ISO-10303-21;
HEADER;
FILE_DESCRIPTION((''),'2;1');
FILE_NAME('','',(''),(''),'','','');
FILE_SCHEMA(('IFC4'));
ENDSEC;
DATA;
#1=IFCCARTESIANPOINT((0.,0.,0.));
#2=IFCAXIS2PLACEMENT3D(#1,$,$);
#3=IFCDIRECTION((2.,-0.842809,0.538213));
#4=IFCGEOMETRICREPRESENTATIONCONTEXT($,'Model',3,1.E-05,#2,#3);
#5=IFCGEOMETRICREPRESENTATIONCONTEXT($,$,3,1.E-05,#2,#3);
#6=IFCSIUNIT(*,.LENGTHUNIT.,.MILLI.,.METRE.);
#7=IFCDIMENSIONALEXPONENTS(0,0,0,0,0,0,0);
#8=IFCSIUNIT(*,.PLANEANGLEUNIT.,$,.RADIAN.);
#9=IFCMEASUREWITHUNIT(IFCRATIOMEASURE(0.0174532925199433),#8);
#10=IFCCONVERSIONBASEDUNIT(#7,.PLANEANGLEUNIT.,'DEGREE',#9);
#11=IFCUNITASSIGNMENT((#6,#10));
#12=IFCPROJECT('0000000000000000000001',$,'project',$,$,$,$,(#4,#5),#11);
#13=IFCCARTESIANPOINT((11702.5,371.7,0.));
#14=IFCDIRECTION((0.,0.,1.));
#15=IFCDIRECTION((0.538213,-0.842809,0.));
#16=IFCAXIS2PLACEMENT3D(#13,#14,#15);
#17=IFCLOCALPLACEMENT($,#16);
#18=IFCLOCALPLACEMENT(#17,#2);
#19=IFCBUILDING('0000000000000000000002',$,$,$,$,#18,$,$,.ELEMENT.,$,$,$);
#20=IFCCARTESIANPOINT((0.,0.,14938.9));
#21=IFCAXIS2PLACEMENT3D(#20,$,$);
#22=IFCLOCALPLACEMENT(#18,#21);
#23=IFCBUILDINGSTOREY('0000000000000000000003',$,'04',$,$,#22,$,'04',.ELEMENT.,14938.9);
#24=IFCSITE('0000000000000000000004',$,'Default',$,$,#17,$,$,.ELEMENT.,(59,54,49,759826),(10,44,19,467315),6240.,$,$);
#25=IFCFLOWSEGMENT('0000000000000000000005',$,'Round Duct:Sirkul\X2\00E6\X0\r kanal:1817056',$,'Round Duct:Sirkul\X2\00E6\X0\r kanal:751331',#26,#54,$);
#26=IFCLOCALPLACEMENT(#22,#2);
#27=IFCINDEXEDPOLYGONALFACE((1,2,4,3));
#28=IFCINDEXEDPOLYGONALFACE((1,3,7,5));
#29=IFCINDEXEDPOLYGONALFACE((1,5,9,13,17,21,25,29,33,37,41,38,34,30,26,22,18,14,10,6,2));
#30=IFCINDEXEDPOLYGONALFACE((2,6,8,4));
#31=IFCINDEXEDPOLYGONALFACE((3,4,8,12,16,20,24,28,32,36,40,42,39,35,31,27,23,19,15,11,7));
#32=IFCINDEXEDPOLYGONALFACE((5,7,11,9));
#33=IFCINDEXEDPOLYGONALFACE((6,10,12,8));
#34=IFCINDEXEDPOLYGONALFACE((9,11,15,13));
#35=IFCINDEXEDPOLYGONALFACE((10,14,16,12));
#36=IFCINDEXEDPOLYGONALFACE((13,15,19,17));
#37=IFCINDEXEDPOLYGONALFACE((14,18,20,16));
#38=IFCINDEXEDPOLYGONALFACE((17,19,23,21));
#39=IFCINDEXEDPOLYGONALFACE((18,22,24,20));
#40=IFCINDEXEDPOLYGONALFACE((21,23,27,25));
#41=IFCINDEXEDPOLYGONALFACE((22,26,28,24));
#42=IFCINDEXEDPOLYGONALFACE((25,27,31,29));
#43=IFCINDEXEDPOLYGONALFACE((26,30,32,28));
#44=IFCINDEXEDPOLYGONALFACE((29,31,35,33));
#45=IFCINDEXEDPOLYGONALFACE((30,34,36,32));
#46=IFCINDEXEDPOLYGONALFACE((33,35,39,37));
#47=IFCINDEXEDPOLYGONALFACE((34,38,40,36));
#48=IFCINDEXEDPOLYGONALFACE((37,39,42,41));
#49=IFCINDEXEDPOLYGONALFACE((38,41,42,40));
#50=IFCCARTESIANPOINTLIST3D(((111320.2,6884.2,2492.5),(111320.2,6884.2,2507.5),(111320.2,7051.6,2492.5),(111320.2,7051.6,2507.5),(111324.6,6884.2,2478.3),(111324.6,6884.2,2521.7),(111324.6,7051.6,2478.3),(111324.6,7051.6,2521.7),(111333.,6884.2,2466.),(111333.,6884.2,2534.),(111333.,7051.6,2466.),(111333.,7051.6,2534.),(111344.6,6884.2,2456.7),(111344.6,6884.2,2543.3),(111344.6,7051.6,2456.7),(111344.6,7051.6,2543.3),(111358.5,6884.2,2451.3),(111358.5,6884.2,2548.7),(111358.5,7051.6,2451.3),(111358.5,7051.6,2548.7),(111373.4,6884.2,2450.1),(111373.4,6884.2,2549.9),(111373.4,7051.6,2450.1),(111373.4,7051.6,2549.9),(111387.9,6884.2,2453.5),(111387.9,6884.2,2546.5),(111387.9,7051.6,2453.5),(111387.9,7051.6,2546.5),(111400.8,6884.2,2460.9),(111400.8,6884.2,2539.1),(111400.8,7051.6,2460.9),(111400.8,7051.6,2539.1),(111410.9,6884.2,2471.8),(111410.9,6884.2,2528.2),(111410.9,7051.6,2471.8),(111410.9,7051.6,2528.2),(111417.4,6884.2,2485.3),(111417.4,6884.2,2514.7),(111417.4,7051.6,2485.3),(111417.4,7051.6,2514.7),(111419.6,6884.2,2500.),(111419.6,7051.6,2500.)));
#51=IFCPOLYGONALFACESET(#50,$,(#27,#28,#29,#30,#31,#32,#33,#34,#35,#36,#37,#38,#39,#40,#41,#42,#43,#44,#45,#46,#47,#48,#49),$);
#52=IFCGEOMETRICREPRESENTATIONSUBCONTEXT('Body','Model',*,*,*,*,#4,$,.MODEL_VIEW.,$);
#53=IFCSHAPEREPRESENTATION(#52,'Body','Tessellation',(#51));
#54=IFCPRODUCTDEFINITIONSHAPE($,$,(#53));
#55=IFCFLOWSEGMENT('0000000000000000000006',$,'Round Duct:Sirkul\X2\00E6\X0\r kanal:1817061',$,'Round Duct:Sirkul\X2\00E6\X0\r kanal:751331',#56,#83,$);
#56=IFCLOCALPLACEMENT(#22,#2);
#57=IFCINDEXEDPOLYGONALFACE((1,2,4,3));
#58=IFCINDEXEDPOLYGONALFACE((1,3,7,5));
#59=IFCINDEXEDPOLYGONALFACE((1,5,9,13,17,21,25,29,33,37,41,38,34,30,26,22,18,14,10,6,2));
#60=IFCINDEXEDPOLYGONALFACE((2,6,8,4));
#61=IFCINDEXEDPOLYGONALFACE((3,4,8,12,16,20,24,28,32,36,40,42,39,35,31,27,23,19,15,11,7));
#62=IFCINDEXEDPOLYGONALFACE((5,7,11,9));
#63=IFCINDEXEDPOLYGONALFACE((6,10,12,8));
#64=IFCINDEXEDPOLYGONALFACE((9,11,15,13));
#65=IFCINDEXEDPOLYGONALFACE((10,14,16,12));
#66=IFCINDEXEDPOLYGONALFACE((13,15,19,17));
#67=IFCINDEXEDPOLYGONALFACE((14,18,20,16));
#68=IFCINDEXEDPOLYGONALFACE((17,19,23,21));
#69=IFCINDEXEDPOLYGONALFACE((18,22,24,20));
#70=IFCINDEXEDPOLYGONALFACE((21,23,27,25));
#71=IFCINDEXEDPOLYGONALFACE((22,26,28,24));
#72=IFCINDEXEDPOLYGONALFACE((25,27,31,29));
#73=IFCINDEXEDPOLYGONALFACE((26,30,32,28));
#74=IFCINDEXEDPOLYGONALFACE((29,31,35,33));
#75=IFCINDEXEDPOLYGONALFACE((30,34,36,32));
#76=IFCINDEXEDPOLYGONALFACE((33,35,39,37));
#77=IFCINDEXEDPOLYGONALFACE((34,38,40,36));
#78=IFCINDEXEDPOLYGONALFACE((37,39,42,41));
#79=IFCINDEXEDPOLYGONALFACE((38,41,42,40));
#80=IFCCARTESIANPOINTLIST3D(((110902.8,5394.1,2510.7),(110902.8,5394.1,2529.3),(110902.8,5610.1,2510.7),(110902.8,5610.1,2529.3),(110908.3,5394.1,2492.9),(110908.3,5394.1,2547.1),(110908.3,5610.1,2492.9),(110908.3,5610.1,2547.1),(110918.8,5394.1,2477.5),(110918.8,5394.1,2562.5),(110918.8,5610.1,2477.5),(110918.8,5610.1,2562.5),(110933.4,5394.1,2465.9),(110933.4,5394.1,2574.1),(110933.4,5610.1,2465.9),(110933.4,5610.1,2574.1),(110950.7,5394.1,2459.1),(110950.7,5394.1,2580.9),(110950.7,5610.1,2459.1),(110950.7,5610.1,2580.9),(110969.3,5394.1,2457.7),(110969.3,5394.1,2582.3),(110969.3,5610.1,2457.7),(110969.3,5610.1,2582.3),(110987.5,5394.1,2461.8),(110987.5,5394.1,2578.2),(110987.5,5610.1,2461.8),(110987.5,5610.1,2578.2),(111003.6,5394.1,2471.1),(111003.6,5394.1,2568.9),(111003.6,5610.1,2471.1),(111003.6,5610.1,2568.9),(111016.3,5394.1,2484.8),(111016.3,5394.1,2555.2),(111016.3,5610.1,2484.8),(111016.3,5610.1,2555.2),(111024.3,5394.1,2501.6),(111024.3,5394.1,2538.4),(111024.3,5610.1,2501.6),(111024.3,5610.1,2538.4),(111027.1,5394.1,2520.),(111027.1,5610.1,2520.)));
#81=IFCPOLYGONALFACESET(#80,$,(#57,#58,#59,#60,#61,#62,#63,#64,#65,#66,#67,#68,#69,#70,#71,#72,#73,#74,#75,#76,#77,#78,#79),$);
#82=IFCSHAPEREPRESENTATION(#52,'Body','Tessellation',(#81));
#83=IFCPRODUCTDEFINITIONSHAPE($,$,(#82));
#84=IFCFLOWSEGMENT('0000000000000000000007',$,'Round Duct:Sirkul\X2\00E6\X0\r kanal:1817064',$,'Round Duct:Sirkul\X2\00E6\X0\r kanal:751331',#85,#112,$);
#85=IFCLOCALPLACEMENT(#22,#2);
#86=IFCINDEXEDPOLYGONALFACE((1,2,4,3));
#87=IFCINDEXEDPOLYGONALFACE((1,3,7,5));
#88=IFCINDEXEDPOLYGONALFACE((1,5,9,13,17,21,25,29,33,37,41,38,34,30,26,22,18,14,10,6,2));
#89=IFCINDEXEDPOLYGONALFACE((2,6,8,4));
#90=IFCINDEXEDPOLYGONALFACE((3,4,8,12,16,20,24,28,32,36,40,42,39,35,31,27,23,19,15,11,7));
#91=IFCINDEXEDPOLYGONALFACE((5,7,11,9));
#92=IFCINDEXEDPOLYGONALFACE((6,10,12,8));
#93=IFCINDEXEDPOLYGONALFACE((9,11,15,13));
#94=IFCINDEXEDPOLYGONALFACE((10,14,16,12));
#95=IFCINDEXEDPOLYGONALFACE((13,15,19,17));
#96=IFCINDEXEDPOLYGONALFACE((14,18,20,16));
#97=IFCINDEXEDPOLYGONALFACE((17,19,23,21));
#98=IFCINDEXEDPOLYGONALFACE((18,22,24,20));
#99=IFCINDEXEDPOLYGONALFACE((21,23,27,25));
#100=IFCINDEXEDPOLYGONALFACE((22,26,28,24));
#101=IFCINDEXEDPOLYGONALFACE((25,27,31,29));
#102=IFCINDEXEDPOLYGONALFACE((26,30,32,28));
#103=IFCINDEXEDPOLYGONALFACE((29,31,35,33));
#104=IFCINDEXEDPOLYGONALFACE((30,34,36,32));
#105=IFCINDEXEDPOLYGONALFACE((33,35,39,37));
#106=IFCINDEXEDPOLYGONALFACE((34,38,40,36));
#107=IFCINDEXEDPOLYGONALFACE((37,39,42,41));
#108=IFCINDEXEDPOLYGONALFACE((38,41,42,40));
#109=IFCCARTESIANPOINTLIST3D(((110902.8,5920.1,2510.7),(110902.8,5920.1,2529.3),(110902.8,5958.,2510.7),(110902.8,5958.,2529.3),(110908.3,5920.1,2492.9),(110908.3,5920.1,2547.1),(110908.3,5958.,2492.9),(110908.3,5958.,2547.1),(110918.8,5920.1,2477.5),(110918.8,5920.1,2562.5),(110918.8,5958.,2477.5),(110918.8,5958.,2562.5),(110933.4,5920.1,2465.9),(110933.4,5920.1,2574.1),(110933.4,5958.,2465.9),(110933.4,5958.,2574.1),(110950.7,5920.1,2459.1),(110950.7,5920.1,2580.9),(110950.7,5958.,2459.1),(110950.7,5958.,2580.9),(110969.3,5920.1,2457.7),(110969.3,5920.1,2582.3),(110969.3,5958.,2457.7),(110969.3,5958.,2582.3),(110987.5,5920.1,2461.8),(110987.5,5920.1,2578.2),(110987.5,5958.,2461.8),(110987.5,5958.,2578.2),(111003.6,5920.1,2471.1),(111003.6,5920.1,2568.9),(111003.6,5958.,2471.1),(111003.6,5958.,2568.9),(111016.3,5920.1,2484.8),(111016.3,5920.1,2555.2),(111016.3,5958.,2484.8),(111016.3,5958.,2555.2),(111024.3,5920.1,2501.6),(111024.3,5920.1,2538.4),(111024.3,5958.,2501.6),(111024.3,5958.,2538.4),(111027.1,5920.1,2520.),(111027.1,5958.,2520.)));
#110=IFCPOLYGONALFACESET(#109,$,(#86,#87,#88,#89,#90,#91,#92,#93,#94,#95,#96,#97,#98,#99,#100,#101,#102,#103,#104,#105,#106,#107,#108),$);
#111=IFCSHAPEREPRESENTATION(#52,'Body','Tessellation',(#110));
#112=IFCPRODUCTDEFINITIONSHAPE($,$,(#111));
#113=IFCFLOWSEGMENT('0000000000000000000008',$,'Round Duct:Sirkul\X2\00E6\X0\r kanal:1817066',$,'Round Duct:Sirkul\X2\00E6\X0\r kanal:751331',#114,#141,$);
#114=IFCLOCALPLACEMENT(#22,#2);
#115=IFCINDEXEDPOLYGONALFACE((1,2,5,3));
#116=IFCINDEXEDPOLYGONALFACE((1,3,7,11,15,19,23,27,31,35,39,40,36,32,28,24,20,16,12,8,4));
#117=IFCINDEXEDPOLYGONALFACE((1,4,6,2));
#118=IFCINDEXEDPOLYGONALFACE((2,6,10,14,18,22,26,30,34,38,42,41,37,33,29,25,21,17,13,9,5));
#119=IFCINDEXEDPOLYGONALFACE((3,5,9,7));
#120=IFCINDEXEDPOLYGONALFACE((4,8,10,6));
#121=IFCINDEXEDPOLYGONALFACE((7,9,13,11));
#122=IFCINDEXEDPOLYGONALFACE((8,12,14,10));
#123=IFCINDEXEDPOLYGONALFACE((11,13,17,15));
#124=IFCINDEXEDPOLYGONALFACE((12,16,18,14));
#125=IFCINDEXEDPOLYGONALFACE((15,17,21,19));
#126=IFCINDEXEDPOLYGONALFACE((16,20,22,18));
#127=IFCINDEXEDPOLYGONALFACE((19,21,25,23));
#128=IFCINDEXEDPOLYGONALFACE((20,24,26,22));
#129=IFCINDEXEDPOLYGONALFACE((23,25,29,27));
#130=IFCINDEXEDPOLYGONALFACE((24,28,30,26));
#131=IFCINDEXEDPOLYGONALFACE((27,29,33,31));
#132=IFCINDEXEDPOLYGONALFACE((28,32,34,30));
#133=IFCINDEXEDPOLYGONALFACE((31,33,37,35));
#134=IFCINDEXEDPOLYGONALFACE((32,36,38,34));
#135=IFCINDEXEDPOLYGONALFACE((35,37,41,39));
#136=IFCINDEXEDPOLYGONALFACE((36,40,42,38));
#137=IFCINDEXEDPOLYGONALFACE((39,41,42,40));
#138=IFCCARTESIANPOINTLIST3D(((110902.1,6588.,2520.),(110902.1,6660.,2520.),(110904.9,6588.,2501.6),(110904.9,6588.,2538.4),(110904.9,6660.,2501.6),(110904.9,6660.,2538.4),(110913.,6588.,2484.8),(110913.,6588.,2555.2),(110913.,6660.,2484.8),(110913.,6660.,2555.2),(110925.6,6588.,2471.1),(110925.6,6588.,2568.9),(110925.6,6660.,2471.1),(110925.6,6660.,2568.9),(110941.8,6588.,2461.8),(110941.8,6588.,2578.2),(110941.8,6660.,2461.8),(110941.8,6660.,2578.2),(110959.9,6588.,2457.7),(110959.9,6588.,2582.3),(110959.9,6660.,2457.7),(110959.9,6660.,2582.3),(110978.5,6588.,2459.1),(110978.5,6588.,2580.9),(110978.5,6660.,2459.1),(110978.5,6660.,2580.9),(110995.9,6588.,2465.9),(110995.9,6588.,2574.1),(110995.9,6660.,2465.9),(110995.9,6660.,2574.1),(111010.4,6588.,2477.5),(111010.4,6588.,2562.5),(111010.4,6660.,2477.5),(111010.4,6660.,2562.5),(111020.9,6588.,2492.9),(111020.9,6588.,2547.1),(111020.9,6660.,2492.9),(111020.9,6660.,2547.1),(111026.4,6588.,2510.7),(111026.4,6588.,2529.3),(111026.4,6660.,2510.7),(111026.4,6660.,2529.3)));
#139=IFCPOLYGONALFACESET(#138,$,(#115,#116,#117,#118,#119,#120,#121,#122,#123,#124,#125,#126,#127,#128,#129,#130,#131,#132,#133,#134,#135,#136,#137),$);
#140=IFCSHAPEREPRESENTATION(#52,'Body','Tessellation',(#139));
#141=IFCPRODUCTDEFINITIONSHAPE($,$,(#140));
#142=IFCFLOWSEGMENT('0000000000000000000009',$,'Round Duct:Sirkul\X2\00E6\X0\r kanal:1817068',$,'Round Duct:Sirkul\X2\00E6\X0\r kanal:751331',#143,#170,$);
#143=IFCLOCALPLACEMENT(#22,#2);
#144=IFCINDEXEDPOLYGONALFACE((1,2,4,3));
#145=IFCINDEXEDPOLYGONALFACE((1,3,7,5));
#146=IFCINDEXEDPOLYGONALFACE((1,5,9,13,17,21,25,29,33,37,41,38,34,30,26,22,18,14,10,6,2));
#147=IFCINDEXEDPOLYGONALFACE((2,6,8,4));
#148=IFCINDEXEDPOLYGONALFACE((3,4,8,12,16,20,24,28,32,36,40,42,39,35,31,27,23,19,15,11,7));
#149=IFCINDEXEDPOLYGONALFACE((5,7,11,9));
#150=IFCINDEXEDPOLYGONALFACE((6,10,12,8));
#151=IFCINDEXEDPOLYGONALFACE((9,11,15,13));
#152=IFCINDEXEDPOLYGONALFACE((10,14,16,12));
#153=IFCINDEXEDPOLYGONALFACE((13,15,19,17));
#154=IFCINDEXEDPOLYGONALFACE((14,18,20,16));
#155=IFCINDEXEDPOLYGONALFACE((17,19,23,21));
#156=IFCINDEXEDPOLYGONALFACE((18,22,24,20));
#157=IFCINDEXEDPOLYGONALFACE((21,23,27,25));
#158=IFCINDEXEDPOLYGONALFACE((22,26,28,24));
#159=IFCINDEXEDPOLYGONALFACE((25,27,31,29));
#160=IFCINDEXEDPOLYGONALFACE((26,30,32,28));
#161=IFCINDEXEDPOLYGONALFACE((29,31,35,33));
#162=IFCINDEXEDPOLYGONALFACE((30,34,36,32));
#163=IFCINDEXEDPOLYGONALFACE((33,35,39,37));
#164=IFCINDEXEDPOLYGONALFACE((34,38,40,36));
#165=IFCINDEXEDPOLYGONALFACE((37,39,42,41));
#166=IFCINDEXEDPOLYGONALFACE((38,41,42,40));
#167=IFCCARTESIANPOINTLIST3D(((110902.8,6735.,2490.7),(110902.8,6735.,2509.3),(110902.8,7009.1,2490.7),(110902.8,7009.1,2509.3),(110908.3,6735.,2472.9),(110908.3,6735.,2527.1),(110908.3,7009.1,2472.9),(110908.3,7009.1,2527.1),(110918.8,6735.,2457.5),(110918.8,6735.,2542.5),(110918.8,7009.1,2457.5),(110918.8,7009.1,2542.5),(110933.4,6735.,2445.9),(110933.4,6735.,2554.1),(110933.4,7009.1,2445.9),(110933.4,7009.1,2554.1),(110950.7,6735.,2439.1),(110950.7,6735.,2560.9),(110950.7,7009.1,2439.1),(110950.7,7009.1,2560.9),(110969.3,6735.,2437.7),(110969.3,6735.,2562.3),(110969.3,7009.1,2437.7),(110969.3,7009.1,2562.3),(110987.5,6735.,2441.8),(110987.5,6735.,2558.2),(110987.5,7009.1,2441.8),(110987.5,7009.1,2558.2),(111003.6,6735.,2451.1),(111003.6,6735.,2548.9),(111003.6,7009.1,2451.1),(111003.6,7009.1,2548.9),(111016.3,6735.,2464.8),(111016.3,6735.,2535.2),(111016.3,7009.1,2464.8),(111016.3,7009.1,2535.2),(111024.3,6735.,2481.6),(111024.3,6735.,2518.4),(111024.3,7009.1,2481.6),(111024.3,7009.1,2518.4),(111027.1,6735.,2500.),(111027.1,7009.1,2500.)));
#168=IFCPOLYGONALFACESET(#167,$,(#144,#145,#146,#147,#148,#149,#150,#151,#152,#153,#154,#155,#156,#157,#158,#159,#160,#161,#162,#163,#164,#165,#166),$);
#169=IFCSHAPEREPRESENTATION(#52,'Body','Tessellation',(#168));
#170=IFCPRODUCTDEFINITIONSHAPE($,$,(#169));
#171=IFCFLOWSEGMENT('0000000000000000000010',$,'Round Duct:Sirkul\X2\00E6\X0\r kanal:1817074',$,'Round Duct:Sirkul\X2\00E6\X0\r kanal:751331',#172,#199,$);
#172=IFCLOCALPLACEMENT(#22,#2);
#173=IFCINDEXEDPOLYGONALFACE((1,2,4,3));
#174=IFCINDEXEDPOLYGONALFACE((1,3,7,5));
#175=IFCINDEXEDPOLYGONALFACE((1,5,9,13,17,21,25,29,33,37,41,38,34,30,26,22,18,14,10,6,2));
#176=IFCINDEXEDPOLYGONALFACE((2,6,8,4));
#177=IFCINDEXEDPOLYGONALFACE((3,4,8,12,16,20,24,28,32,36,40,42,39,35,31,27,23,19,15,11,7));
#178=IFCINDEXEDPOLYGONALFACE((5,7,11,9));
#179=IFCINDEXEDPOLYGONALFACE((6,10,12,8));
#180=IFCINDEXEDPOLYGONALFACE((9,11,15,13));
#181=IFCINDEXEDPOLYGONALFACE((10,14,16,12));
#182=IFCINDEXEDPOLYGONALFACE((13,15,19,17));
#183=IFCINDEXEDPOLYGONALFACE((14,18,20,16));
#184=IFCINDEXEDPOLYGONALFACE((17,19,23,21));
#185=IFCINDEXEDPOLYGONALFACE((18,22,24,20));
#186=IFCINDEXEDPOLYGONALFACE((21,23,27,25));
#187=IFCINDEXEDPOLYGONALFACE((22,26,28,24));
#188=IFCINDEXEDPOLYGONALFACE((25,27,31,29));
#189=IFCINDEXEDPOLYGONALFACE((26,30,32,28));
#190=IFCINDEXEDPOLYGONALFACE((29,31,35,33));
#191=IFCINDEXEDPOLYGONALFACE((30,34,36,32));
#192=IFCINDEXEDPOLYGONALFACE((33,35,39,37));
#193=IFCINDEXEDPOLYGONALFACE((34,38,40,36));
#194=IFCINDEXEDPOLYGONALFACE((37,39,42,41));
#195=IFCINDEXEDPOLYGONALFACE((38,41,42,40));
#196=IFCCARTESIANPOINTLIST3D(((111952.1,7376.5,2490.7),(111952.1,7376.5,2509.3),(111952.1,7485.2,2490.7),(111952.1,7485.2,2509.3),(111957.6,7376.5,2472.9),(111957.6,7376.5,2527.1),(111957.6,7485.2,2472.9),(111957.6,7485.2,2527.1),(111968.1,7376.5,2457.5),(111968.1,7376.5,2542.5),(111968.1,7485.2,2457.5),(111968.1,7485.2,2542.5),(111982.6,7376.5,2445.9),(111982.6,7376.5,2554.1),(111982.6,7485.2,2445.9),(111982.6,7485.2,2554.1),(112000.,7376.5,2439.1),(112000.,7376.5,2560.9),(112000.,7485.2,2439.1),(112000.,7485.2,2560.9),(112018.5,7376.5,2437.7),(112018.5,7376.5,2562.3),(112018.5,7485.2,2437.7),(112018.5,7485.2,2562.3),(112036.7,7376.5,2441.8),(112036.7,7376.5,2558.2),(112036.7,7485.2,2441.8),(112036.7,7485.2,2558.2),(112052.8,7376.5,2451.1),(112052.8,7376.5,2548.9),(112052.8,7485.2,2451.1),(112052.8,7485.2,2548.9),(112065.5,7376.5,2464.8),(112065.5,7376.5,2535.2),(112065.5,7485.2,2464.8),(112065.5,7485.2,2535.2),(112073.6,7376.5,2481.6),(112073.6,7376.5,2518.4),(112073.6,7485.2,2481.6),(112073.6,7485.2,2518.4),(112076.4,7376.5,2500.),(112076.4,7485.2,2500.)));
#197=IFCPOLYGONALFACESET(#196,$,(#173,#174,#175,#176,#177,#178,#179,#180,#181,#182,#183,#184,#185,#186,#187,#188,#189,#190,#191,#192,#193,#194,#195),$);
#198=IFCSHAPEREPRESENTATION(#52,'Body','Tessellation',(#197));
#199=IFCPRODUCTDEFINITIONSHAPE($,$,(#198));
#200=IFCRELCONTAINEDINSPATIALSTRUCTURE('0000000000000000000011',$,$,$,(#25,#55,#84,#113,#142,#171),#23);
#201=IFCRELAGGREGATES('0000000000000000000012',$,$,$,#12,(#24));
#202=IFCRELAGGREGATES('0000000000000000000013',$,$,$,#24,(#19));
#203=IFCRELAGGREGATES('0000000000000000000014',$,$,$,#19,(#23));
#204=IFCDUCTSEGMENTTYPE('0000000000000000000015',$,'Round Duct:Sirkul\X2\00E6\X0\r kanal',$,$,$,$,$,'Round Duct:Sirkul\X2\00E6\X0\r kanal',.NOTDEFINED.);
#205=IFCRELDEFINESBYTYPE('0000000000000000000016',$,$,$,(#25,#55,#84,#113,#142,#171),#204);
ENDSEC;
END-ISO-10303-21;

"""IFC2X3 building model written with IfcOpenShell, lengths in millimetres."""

from ifc_helpers import new_model, entity, si_unit, converted_unit, direction, frame, frame_2d, origin, origin_2d_with_axis, place, context, subcontext, project, spatial, circle, extrude, type_object, element, save


model = new_model("IFC2X3")

# Units and contexts
model_context = context("Model", 3, precision=1e-05, world=origin(), true_north=direction((2.0, -0.842809, 0.538213)))
context_of_model = context(None, 3, precision=1e-05, world=origin(), true_north=direction((2.0, -0.842809, 0.538213)))
body_context = subcontext(model_context, "Body", "Model", "MODEL_VIEW")
ifc_project = project(units=[si_unit("LENGTHUNIT", "METRE", prefix="MILLI"), converted_unit("PLANEANGLEUNIT", "DEGREE", entity("IfcRatioMeasure", 0.0174532925199433), si_unit("PLANEANGLEUNIT", "RADIAN"), dimensions=[0, 0, 0, 0, 0, 0, 0])], contexts=[model_context, context_of_model])

# Site, building, storey
site_placement = place(None, frame((11702.5, 371.7, 0.0), z_axis=(0.0, 0.0, 1.0), x_axis=(0.538213, -0.842809, 0.0)))
site = spatial("IfcSite", under=ifc_project, at=site_placement, Name="Default", CompositionType="ELEMENT", RefLatitude=(59, 54, 49, 759826), RefLongitude=(10, 44, 19, 467315), RefElevation=6240.0)
building_placement = place(site_placement, origin())
building = spatial("IfcBuilding", under=site, at=building_placement, CompositionType="ELEMENT")
storey_placement = place(building_placement, frame((0.0, 0.0, 14938.9)))
storey = spatial("IfcBuildingStorey", under=building, at=storey_placement, Name="04", LongName="04", CompositionType="ELEMENT", Elevation=14938.9)

# Flow segments
duct_segment_type = type_object("IfcDuctSegmentType", Name="Round Duct:Sirkulær kanal", ElementType="Round Duct:Sirkulær kanal", PredefinedType="NOTDEFINED")
flow_segment_1_placement = place(storey_placement, origin())
element("IfcFlowSegment", 1, at=flow_segment_1_placement, inside=storey, type_object=duct_segment_type, Name="Round Duct:Sirkulær kanal:1817056", ObjectType="Round Duct:Sirkulær kanal:751331", context=body_context, shape_type="SweptSolid", body=[
    extrude(circle(Radius=50.0, at=origin_2d_with_axis()), frame((111369.6, 6884.2, 2500.0), z_axis=(0.0, 1.0, 0.0), x_axis=(1.0, 0.0, 0.0)), (0.0, 0.0, 1.0), 167.5),
])
flow_segment_2_placement = place(storey_placement, origin())
element("IfcFlowSegment", 2, at=flow_segment_2_placement, inside=storey, type_object=duct_segment_type, Name="Round Duct:Sirkulær kanal:1817061", ObjectType="Round Duct:Sirkulær kanal:751331", context=body_context, shape_type="SweptSolid", body=[
    extrude(circle(Radius=62.5, at=frame_2d((0.0, 0.0), x_axis=(1.0, 0.0))), frame((110964.6, 5394.1, 2520.0), z_axis=(0.0, 1.0, 0.0), x_axis=(1.0, 0.0, 0.0)), (0.0, 0.0, 1.0), 216.0),
])
flow_segment_3_placement = place(storey_placement, origin())
element("IfcFlowSegment", 3, at=flow_segment_3_placement, inside=storey, type_object=duct_segment_type, Name="Round Duct:Sirkulær kanal:1817064", ObjectType="Round Duct:Sirkulær kanal:751331", context=body_context, shape_type="SweptSolid", body=[
    extrude(circle(Radius=62.5, at=frame_2d((0.0, 0.0), x_axis=(1.0, 0.0))), frame((110964.6, 5920.1, 2520.0), z_axis=(0.0, 1.0, 0.0), x_axis=(1.0, 0.0, 0.0)), (0.0, 0.0, 1.0), 37.9),
])
flow_segment_4_placement = place(storey_placement, origin())
element("IfcFlowSegment", 4, at=flow_segment_4_placement, inside=storey, type_object=duct_segment_type, Name="Round Duct:Sirkulær kanal:1817066", ObjectType="Round Duct:Sirkulær kanal:751331", context=body_context, shape_type="SweptSolid", body=[
    extrude(circle(Radius=62.5, at=frame_2d((0.0, 0.0), x_axis=(1.0, 0.0))), frame((110964.6, 6588.0, 2520.0), z_axis=(0.0, 1.0, 0.0), x_axis=(-1.0, 0.0, 0.0)), (0.0, 0.0, 1.0), 72.0),
])
flow_segment_5_placement = place(storey_placement, origin())
element("IfcFlowSegment", 5, at=flow_segment_5_placement, inside=storey, type_object=duct_segment_type, Name="Round Duct:Sirkulær kanal:1817068", ObjectType="Round Duct:Sirkulær kanal:751331", context=body_context, shape_type="SweptSolid", body=[
    extrude(circle(Radius=62.5, at=origin_2d_with_axis()), frame((110964.6, 6735.0, 2500.0), z_axis=(0.0, 1.0, 0.0), x_axis=(1.0, 0.0, 0.0)), (0.0, 0.0, 1.0), 274.1),
])
flow_segment_6_placement = place(storey_placement, origin())
element("IfcFlowSegment", 6, at=flow_segment_6_placement, inside=storey, type_object=duct_segment_type, Name="Round Duct:Sirkulær kanal:1817074", ObjectType="Round Duct:Sirkulær kanal:751331", context=body_context, shape_type="SweptSolid", body=[
    extrude(circle(Radius=62.5, at=frame_2d((0.0, 0.0), x_axis=(1.0, 0.0))), frame((112013.9, 7376.5, 2500.0), z_axis=(0.000003, 1.0, 0.0), x_axis=(1.0, -0.000003, 0.0)), (0.0, 0.0, 1.0), 108.7),
])

save(model, "model.ifc")
